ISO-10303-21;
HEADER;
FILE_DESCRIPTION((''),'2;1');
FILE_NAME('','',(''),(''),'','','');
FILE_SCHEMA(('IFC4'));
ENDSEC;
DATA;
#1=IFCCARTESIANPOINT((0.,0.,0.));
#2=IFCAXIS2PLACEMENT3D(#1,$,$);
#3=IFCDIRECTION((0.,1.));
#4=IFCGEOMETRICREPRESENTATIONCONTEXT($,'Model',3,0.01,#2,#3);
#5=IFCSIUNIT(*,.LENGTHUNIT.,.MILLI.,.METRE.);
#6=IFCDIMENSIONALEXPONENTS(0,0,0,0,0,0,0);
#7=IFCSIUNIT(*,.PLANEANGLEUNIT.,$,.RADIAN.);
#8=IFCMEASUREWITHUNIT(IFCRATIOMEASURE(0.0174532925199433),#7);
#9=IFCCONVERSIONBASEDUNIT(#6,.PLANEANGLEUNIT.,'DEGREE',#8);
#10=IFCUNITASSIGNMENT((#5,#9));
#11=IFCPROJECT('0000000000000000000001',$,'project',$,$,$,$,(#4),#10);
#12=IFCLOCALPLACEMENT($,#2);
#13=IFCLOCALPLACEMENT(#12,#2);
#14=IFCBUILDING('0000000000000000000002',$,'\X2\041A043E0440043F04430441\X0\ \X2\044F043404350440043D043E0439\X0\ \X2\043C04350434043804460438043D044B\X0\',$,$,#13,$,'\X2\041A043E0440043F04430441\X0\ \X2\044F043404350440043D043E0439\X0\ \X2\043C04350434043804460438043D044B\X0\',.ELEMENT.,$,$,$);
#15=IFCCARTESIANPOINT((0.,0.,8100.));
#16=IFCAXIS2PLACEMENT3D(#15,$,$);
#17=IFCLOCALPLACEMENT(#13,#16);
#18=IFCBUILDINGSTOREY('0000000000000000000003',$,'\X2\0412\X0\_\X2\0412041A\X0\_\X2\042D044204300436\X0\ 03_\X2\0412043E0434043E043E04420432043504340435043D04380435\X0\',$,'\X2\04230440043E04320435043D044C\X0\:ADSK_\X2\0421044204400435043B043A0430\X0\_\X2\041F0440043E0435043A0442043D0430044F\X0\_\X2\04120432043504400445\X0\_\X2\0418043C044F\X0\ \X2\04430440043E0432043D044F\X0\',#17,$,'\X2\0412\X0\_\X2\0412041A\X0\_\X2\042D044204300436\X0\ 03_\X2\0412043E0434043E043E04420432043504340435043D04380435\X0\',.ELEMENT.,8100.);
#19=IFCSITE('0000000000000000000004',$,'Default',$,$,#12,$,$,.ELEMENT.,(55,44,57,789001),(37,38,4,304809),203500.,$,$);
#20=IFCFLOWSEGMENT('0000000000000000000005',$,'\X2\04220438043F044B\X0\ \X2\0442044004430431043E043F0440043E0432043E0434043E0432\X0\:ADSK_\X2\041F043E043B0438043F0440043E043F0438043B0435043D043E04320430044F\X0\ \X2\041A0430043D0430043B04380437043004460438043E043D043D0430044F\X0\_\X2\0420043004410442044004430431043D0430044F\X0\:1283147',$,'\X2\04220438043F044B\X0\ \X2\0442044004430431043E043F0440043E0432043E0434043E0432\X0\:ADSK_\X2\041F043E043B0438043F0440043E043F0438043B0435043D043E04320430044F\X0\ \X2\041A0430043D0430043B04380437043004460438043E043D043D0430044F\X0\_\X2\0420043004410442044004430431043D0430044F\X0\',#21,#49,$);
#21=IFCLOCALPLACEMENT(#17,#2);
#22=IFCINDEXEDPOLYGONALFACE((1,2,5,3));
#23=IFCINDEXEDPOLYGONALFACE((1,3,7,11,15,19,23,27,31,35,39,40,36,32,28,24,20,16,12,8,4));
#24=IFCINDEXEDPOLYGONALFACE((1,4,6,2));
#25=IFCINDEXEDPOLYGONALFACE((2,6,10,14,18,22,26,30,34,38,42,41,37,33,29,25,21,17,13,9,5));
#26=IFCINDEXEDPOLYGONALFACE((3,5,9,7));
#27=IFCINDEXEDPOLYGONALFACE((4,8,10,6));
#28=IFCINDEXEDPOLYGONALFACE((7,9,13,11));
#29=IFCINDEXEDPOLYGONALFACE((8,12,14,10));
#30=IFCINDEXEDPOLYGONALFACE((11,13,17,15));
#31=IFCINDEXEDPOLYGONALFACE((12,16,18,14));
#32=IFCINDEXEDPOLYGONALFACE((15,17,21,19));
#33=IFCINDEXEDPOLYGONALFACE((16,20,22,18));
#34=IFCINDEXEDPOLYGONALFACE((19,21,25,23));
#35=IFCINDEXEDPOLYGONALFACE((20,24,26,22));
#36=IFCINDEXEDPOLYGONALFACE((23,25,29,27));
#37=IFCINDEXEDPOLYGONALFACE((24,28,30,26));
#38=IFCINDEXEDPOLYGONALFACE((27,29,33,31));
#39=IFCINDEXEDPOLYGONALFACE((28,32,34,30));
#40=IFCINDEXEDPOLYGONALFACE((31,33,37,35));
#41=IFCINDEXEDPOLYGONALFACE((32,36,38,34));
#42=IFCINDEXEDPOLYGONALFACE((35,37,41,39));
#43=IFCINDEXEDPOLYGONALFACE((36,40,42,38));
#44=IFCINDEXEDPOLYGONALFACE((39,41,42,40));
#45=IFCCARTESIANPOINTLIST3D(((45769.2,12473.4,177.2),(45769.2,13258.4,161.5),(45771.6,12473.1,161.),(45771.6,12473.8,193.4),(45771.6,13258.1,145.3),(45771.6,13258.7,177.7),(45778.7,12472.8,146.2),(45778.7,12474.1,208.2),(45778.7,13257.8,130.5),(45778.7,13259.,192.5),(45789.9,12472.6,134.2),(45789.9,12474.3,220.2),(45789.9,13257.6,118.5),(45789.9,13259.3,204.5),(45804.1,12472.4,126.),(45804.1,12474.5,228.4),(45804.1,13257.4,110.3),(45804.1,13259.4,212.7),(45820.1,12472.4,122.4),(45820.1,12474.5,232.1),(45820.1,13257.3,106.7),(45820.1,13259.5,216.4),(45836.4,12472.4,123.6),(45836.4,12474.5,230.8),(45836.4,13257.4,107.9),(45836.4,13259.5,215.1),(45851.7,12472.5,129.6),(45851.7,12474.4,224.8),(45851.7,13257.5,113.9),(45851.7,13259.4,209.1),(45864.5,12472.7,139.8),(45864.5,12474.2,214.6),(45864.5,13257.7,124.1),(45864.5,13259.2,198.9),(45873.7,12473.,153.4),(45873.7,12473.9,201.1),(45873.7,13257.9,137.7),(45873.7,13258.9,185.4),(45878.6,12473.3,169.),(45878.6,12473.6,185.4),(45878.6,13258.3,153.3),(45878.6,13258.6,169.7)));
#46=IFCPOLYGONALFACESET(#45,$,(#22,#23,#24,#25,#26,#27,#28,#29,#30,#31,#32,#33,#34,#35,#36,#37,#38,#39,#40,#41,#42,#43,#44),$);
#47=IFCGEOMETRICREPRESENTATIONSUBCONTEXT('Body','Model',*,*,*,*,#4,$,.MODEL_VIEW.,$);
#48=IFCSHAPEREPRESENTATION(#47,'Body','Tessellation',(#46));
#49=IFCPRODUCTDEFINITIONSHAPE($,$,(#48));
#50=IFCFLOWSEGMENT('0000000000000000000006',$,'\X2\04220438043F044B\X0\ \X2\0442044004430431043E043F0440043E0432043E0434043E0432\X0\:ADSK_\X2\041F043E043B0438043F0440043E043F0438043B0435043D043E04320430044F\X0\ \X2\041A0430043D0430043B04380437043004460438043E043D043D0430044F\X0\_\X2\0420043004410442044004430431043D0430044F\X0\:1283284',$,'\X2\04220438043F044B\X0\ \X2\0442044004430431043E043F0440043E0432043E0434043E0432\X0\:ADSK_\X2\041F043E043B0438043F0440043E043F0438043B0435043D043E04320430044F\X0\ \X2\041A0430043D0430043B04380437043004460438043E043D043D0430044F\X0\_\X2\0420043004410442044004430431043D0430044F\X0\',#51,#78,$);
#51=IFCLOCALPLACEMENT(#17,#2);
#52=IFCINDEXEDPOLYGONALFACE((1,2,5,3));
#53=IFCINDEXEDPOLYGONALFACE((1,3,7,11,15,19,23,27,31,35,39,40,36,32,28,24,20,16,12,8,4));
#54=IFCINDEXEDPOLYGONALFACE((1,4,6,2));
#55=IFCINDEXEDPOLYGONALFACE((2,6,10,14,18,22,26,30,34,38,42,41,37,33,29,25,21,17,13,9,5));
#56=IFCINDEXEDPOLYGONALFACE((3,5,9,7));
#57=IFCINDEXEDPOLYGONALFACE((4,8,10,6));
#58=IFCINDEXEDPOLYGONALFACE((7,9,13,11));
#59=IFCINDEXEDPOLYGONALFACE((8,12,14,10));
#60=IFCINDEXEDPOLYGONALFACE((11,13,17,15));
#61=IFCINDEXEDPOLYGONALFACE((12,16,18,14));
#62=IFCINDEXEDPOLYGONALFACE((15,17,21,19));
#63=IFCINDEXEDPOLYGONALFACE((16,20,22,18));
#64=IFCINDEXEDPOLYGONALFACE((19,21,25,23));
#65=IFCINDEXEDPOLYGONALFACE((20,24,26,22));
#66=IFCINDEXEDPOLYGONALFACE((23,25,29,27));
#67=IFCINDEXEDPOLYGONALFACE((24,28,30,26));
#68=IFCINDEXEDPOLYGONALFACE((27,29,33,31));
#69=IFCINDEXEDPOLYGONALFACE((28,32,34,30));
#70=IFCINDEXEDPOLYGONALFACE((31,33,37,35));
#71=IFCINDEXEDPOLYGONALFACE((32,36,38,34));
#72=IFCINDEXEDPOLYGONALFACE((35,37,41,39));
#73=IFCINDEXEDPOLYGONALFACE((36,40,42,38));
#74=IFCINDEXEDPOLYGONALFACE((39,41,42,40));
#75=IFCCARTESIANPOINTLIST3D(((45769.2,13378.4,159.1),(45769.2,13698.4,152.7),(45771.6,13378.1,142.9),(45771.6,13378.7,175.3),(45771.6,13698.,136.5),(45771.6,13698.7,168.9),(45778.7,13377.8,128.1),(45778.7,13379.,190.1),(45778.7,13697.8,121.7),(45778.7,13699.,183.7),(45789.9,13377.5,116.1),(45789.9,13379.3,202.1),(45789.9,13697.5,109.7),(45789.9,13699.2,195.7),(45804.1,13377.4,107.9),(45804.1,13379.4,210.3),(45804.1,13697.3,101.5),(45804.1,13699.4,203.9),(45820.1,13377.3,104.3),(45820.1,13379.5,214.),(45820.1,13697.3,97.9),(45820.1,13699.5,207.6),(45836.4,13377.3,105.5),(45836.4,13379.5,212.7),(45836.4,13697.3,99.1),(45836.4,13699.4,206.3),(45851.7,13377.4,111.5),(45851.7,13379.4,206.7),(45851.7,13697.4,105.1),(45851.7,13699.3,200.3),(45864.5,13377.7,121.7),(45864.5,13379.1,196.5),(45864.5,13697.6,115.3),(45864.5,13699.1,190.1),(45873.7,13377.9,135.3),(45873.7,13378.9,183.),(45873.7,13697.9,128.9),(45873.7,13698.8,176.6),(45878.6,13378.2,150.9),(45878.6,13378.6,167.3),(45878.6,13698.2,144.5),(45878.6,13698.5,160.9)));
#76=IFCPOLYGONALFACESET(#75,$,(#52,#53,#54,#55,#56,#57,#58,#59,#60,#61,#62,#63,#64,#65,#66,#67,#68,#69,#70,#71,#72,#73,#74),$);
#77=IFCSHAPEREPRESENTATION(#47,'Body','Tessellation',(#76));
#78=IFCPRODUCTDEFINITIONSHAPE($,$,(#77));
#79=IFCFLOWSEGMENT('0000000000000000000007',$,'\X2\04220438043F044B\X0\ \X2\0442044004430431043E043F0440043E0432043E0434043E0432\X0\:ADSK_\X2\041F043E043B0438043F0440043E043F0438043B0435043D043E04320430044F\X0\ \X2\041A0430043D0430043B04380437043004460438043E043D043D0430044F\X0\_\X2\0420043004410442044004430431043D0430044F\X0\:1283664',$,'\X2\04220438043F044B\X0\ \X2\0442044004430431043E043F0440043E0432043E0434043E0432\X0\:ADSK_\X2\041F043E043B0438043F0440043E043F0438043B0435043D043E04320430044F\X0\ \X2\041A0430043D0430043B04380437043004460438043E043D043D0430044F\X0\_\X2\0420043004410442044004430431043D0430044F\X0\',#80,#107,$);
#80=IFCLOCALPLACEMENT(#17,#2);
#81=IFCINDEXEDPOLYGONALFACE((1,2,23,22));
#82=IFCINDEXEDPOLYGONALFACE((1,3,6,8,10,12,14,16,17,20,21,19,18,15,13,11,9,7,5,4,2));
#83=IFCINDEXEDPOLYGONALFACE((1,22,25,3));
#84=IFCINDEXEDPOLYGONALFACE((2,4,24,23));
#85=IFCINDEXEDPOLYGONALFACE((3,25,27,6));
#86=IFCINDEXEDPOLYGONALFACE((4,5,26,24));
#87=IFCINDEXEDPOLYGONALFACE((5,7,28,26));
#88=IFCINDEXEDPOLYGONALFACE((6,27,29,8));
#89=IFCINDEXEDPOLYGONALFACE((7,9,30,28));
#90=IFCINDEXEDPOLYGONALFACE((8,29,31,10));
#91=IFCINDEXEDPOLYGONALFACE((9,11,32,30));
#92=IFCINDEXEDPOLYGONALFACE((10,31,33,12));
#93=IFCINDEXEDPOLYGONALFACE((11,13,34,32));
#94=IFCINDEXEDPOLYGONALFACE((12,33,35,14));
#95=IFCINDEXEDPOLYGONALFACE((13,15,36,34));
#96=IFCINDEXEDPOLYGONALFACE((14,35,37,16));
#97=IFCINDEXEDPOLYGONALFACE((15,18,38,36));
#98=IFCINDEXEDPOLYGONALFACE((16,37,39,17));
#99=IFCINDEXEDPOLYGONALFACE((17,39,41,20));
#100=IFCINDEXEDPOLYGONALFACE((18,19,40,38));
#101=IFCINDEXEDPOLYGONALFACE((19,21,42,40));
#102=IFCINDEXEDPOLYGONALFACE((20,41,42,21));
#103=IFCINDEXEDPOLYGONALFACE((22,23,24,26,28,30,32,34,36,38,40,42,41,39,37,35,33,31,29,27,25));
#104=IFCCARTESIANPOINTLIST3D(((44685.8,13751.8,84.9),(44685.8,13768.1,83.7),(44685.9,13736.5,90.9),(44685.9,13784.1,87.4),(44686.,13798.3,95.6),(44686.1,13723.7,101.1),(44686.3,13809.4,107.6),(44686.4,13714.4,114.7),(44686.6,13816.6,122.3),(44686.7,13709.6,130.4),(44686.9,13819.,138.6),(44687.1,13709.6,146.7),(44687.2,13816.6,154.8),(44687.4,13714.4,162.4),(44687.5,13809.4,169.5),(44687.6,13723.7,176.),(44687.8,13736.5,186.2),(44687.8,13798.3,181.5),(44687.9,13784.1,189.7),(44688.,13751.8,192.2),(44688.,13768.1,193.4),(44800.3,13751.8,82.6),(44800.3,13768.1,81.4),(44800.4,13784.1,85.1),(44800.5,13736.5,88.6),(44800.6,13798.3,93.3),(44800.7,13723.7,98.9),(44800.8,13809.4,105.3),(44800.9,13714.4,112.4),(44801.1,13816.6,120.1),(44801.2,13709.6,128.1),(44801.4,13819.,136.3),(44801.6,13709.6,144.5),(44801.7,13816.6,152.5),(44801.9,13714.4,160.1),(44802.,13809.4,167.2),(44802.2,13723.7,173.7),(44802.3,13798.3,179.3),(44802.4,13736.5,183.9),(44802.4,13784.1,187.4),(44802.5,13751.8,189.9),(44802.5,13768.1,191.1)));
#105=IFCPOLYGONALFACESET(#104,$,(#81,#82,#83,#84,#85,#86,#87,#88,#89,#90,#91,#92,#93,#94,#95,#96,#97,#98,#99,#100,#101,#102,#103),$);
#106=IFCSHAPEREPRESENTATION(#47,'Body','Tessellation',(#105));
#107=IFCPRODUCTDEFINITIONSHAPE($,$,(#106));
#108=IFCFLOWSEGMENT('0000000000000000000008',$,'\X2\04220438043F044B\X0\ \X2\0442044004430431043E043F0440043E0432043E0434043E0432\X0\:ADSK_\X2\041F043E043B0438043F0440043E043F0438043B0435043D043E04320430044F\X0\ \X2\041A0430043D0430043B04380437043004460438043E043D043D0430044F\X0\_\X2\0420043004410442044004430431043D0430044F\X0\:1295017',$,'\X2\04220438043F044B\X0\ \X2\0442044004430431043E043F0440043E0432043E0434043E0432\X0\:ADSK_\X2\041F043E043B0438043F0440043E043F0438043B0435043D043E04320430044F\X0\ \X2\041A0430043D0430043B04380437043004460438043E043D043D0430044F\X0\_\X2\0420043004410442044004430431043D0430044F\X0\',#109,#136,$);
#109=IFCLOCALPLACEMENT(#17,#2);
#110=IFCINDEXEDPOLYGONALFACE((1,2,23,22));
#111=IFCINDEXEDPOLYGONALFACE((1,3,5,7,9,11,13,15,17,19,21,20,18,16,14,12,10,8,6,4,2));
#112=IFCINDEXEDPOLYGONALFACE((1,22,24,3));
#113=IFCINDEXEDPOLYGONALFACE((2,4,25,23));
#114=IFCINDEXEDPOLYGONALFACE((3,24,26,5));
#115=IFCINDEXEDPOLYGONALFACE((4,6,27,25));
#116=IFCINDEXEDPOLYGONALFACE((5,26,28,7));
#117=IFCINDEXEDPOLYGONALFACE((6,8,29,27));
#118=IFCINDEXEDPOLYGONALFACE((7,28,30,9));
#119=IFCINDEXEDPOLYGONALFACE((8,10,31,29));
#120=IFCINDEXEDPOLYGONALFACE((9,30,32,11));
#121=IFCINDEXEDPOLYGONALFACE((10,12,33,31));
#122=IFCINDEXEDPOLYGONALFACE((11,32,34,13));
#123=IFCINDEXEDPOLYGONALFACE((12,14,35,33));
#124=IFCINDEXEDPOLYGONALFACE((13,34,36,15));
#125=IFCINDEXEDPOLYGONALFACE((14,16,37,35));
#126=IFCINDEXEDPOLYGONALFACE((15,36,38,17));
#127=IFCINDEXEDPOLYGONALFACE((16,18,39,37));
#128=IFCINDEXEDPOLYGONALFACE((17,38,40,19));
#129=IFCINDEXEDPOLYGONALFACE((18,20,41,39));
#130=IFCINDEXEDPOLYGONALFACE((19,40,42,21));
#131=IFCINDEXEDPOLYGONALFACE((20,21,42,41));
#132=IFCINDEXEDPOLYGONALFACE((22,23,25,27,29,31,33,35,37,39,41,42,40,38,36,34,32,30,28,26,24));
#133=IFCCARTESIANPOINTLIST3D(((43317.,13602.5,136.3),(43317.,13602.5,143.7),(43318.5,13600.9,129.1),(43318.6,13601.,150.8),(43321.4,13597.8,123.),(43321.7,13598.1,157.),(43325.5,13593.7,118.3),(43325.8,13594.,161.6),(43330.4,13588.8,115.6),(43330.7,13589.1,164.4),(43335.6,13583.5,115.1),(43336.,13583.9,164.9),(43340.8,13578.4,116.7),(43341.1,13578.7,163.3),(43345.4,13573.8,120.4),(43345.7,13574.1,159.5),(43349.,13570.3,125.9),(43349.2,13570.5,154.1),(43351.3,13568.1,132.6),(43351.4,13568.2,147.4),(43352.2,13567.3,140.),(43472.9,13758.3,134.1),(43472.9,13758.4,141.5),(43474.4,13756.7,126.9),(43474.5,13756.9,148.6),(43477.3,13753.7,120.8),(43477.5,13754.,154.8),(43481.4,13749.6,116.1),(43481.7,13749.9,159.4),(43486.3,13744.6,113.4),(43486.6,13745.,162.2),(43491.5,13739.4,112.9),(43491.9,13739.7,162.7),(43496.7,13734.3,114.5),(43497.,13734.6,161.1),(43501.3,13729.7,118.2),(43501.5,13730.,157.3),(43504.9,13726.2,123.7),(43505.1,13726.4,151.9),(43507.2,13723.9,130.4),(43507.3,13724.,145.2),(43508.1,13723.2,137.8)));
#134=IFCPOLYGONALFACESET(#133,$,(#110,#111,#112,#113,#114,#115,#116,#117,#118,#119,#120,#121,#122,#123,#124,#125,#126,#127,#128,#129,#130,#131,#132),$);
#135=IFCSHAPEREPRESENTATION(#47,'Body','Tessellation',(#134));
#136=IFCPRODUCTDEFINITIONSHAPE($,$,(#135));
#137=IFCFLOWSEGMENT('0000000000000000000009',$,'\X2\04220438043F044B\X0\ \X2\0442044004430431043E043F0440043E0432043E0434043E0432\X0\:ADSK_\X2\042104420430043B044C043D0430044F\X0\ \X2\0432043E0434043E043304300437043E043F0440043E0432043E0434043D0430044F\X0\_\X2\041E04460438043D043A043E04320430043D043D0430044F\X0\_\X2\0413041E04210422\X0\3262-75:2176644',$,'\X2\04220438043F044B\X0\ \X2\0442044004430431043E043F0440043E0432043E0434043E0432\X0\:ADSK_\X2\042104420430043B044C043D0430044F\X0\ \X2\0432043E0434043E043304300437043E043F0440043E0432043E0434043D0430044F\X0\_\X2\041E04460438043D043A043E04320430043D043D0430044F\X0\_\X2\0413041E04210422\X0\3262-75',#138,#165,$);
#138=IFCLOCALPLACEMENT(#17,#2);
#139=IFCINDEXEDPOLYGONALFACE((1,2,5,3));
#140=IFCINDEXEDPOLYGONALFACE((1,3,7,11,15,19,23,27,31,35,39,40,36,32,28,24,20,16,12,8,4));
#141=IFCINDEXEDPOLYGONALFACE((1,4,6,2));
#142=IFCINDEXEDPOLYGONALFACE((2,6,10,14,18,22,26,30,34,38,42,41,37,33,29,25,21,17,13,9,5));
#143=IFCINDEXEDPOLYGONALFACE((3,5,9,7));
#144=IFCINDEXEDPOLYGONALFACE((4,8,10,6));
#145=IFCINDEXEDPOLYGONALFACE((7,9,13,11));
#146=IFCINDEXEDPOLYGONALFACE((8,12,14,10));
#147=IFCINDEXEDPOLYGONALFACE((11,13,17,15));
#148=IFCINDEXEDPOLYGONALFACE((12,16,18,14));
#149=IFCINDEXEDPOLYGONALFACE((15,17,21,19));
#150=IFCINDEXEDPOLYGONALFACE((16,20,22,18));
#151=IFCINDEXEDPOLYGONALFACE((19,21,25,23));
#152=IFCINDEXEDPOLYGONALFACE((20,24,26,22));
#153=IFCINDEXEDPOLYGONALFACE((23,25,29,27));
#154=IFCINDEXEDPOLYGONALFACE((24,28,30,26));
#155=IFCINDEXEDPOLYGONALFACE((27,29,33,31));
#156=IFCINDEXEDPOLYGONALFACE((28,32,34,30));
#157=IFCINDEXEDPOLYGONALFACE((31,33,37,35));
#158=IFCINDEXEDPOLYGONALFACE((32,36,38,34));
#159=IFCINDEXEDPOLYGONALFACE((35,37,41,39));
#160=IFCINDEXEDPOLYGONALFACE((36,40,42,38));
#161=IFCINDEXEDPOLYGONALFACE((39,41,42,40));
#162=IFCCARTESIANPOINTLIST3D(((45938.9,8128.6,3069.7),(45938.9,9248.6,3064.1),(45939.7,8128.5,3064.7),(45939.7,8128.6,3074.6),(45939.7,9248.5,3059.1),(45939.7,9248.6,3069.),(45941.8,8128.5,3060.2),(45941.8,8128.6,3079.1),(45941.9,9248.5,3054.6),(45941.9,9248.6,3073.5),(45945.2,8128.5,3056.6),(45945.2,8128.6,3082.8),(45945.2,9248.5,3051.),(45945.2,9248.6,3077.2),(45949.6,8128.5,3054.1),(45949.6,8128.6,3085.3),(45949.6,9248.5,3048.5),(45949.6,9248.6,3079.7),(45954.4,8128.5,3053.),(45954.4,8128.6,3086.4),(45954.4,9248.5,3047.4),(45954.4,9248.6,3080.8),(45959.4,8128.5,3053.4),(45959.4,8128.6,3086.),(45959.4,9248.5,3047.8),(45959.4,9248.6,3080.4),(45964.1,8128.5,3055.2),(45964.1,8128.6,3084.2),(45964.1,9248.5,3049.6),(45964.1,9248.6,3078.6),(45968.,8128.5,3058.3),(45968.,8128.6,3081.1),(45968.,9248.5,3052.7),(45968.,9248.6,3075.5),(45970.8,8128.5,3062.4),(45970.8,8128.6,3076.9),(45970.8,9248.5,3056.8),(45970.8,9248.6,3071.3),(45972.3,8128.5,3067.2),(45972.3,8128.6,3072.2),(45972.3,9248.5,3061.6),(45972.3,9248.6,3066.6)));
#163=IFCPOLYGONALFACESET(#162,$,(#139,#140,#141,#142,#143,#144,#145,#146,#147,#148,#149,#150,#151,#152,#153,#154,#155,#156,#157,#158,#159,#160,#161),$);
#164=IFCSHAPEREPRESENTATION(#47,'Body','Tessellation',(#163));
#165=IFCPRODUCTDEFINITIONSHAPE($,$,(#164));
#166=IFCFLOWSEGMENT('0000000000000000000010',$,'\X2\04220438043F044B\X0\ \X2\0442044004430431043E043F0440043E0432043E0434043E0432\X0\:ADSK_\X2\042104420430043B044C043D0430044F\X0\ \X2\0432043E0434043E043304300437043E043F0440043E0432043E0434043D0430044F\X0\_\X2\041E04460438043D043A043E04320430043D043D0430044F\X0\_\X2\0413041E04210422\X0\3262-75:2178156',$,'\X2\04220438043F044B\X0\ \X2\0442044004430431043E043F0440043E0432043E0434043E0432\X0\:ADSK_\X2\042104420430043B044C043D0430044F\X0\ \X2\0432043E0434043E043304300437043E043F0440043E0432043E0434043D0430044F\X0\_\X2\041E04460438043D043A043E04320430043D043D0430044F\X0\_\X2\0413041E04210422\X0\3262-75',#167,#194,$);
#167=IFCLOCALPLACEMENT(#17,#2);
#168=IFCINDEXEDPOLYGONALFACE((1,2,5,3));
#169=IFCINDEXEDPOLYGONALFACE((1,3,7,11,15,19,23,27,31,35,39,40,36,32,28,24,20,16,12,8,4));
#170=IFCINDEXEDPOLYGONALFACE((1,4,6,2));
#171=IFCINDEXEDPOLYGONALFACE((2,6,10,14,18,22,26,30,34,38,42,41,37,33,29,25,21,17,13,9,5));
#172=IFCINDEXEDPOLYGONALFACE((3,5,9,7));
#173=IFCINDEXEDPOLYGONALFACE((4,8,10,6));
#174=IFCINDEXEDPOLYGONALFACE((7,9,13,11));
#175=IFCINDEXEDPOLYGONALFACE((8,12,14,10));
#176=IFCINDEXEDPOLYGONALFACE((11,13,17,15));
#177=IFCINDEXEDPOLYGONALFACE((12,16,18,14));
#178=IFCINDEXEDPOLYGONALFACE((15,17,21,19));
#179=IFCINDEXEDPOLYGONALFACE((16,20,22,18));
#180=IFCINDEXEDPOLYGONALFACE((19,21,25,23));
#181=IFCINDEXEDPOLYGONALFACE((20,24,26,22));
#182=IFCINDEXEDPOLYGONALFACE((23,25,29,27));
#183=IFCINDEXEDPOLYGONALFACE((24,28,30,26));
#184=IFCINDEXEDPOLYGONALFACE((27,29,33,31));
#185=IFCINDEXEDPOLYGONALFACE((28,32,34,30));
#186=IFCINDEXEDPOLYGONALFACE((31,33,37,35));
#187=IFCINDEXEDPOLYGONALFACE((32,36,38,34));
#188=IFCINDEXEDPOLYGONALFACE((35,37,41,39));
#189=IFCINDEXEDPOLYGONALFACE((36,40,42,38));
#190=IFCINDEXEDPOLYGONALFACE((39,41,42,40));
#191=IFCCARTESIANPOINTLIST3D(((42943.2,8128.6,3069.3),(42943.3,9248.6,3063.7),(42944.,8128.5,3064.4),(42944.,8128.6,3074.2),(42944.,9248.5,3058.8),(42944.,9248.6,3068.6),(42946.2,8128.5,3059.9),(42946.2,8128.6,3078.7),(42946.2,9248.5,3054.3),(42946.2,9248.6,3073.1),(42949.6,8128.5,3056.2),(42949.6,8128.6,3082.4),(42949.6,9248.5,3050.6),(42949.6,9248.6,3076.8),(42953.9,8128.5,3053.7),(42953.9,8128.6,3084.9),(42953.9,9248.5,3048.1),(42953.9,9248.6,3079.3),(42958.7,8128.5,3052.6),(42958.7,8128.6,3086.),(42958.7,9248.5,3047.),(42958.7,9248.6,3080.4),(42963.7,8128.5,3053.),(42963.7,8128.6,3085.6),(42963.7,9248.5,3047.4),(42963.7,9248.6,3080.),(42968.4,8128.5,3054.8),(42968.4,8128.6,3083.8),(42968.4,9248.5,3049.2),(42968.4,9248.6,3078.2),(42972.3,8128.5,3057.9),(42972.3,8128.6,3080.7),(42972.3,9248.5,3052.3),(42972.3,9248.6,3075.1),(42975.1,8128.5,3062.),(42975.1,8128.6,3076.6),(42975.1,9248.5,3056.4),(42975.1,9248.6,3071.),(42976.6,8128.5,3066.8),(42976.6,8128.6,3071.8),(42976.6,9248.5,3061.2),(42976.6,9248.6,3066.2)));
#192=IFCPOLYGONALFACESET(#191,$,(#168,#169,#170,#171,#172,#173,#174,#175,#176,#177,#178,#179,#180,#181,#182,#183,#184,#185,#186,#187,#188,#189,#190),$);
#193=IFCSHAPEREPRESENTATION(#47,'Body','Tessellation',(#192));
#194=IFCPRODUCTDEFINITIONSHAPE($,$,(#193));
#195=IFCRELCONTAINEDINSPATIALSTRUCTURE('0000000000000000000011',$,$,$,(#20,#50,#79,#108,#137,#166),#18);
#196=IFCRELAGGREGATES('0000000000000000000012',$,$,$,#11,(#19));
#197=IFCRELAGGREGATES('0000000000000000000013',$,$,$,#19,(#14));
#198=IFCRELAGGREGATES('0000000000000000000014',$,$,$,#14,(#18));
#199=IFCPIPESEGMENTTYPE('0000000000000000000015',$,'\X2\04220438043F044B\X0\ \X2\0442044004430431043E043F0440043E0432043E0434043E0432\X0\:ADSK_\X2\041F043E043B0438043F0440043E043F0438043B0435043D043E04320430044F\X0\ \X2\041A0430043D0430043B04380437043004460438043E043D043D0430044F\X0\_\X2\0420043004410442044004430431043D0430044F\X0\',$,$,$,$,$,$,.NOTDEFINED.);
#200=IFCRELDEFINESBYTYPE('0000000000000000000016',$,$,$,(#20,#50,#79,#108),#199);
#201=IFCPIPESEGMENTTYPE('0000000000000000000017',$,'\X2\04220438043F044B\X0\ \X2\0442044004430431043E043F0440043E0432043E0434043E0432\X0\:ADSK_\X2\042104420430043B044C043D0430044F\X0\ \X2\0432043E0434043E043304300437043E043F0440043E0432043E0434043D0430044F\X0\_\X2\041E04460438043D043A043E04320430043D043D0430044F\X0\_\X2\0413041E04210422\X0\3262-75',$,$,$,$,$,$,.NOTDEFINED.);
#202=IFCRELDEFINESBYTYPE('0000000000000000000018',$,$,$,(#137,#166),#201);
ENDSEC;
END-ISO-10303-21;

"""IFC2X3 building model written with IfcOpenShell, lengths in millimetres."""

from ifc_helpers import new_model, entity, si_unit, converted_unit, direction, frame, origin, origin_2d_with_axis, place, context, subcontext, project, spatial, circle, extrude, type_object, element, save


model = new_model("IFC2X3")

# Units and contexts
model_context = context("Model", 3, precision=0.01, world=origin(), true_north=direction((0.0, 1.0)))
body_context = subcontext(model_context, "Body", "Model", "MODEL_VIEW")
ifc_project = project(units=[si_unit("LENGTHUNIT", "METRE", prefix="MILLI"), converted_unit("PLANEANGLEUNIT", "DEGREE", entity("IfcRatioMeasure", 0.0174532925199433), si_unit("PLANEANGLEUNIT", "RADIAN"), dimensions=[0, 0, 0, 0, 0, 0, 0])], contexts=[model_context])

# Site, building, storey
site_placement = place(None, origin())
site = spatial("IfcSite", under=ifc_project, at=site_placement, Name="Default", CompositionType="ELEMENT", RefLatitude=(55, 44, 57, 789001), RefLongitude=(37, 38, 4, 304809), RefElevation=203500.0)
building_placement = place(site_placement, origin())
building = spatial("IfcBuilding", under=site, at=building_placement, Name="Корпус ядерной медицины", LongName="Корпус ядерной медицины", CompositionType="ELEMENT")
storey_placement = place(building_placement, frame((0.0, 0.0, 8100.0)))
storey = spatial("IfcBuildingStorey", under=building, at=storey_placement, Name="В_ВК_Этаж 03_Водоотведение", ObjectType="Уровень:ADSK_Стрелка_Проектная_Вверх_Имя уровня", LongName="В_ВК_Этаж 03_Водоотведение", CompositionType="ELEMENT", Elevation=8100.0)

# Flow segments
pipe_segment_type_1 = type_object("IfcPipeSegmentType", Name="Типы трубопроводов:ADSK_Полипропиленовая Канализационная_Раструбная", PredefinedType="NOTDEFINED")
flow_segment_1_placement = place(storey_placement, frame((45767.6, 12470.8, 104.9)))
element("IfcFlowSegment", 1, at=flow_segment_1_placement, inside=storey, type_object=pipe_segment_type_1, Name="Типы трубопроводов:ADSK_Полипропиленовая Канализационная_Раструбная:1283147", ObjectType="Типы трубопроводов:ADSK_Полипропиленовая Канализационная_Раструбная", context=body_context, shape_type="SweptSolid", body=[
    extrude(circle(Radius=55.0, at=origin_2d_with_axis()), frame((56.6, 2.7, 72.3), z_axis=(0.0, 0.9998, -0.019996), x_axis=(-1.0, 0.0, 0.0)), (0.0, 0.0, 1.0), 785.1),
])
flow_segment_2_placement = place(storey_placement, frame((45767.6, 13375.7, 96.1)))
element("IfcFlowSegment", 2, at=flow_segment_2_placement, inside=storey, type_object=pipe_segment_type_1, Name="Типы трубопроводов:ADSK_Полипропиленовая Канализационная_Раструбная:1283284", ObjectType="Типы трубопроводов:ADSK_Полипропиленовая Канализационная_Раструбная", context=body_context, shape_type="SweptSolid", body=[
    extrude(circle(Radius=55.0, at=origin_2d_with_axis()), frame((56.6, 2.7, 63.0), z_axis=(0.0, 0.9998, -0.019996), x_axis=(-1.0, 0.0, 0.0)), (0.0, 0.0, 1.0), 320.0),
])
flow_segment_3_placement = place(storey_placement, frame((44684.2, 13707.4, 79.7)))
element("IfcFlowSegment", 3, at=flow_segment_3_placement, inside=storey, type_object=pipe_segment_type_1, Name="Типы трубопроводов:ADSK_Полипропиленовая Канализационная_Раструбная:1283664", ObjectType="Типы трубопроводов:ADSK_Полипропиленовая Канализационная_Раструбная", context=body_context, shape_type="SweptSolid", body=[
    extrude(circle(Radius=55.0, at=origin_2d_with_axis()), frame((117.2, 56.6, 56.6), z_axis=(-0.9998, 0.0, 0.019996), x_axis=(0.0, 1.0, 0.0)), (0.0, 0.0, 1.0), 114.5),
])
flow_segment_4_placement = place(storey_placement, frame((43315.2, 13565.7, 111.2)))
element("IfcFlowSegment", 4, at=flow_segment_4_placement, inside=storey, type_object=pipe_segment_type_1, Name="Типы трубопроводов:ADSK_Полипропиленовая Канализационная_Раструбная:1295017", ObjectType="Типы трубопроводов:ADSK_Полипропиленовая Канализационная_Раструбная", context=body_context, shape_type="SweptSolid", body=[
    extrude(circle(Radius=25.0, at=origin_2d_with_axis()), frame((175.2, 175.2, 26.6), z_axis=(-0.707089, -0.707054, 0.01), x_axis=(0.707089, -0.707124, 0.0)), (0.0, 0.0, 1.0), 220.5),
])
pipe_segment_type_2 = type_object("IfcPipeSegmentType", Name="Типы трубопроводов:ADSK_Стальная водогазопроводная_Оцинкованная_ГОСТ3262-75", PredefinedType="NOTDEFINED")
for number, where, name in (
    (5, (45937.3, 8128.5, 3045.7), "Типы трубопроводов:ADSK_Стальная водогазопроводная_Оцинкованная_ГОСТ3262-75:2176644"),
    (6, (42941.7, 8128.5, 3045.3), "Типы трубопроводов:ADSK_Стальная водогазопроводная_Оцинкованная_ГОСТ3262-75:2178156"),
):
    element("IfcFlowSegment", number, at=place(storey_placement, frame(where)), inside=storey, type_object=pipe_segment_type_2, Name=name, ObjectType="Типы трубопроводов:ADSK_Стальная водогазопроводная_Оцинкованная_ГОСТ3262-75", context=body_context, shape_type="SweptSolid", body=[
        extrude(circle(Radius=16.8, at=origin_2d_with_axis()), frame((18.4, 1120.1, 18.4), z_axis=(-0.000001, -0.999987, 0.005), x_axis=(-1.0, 0.000001, 0.0)), (0.0, 0.0, 1.0), 1120.0),
    ])

save(model, "model.ifc")
